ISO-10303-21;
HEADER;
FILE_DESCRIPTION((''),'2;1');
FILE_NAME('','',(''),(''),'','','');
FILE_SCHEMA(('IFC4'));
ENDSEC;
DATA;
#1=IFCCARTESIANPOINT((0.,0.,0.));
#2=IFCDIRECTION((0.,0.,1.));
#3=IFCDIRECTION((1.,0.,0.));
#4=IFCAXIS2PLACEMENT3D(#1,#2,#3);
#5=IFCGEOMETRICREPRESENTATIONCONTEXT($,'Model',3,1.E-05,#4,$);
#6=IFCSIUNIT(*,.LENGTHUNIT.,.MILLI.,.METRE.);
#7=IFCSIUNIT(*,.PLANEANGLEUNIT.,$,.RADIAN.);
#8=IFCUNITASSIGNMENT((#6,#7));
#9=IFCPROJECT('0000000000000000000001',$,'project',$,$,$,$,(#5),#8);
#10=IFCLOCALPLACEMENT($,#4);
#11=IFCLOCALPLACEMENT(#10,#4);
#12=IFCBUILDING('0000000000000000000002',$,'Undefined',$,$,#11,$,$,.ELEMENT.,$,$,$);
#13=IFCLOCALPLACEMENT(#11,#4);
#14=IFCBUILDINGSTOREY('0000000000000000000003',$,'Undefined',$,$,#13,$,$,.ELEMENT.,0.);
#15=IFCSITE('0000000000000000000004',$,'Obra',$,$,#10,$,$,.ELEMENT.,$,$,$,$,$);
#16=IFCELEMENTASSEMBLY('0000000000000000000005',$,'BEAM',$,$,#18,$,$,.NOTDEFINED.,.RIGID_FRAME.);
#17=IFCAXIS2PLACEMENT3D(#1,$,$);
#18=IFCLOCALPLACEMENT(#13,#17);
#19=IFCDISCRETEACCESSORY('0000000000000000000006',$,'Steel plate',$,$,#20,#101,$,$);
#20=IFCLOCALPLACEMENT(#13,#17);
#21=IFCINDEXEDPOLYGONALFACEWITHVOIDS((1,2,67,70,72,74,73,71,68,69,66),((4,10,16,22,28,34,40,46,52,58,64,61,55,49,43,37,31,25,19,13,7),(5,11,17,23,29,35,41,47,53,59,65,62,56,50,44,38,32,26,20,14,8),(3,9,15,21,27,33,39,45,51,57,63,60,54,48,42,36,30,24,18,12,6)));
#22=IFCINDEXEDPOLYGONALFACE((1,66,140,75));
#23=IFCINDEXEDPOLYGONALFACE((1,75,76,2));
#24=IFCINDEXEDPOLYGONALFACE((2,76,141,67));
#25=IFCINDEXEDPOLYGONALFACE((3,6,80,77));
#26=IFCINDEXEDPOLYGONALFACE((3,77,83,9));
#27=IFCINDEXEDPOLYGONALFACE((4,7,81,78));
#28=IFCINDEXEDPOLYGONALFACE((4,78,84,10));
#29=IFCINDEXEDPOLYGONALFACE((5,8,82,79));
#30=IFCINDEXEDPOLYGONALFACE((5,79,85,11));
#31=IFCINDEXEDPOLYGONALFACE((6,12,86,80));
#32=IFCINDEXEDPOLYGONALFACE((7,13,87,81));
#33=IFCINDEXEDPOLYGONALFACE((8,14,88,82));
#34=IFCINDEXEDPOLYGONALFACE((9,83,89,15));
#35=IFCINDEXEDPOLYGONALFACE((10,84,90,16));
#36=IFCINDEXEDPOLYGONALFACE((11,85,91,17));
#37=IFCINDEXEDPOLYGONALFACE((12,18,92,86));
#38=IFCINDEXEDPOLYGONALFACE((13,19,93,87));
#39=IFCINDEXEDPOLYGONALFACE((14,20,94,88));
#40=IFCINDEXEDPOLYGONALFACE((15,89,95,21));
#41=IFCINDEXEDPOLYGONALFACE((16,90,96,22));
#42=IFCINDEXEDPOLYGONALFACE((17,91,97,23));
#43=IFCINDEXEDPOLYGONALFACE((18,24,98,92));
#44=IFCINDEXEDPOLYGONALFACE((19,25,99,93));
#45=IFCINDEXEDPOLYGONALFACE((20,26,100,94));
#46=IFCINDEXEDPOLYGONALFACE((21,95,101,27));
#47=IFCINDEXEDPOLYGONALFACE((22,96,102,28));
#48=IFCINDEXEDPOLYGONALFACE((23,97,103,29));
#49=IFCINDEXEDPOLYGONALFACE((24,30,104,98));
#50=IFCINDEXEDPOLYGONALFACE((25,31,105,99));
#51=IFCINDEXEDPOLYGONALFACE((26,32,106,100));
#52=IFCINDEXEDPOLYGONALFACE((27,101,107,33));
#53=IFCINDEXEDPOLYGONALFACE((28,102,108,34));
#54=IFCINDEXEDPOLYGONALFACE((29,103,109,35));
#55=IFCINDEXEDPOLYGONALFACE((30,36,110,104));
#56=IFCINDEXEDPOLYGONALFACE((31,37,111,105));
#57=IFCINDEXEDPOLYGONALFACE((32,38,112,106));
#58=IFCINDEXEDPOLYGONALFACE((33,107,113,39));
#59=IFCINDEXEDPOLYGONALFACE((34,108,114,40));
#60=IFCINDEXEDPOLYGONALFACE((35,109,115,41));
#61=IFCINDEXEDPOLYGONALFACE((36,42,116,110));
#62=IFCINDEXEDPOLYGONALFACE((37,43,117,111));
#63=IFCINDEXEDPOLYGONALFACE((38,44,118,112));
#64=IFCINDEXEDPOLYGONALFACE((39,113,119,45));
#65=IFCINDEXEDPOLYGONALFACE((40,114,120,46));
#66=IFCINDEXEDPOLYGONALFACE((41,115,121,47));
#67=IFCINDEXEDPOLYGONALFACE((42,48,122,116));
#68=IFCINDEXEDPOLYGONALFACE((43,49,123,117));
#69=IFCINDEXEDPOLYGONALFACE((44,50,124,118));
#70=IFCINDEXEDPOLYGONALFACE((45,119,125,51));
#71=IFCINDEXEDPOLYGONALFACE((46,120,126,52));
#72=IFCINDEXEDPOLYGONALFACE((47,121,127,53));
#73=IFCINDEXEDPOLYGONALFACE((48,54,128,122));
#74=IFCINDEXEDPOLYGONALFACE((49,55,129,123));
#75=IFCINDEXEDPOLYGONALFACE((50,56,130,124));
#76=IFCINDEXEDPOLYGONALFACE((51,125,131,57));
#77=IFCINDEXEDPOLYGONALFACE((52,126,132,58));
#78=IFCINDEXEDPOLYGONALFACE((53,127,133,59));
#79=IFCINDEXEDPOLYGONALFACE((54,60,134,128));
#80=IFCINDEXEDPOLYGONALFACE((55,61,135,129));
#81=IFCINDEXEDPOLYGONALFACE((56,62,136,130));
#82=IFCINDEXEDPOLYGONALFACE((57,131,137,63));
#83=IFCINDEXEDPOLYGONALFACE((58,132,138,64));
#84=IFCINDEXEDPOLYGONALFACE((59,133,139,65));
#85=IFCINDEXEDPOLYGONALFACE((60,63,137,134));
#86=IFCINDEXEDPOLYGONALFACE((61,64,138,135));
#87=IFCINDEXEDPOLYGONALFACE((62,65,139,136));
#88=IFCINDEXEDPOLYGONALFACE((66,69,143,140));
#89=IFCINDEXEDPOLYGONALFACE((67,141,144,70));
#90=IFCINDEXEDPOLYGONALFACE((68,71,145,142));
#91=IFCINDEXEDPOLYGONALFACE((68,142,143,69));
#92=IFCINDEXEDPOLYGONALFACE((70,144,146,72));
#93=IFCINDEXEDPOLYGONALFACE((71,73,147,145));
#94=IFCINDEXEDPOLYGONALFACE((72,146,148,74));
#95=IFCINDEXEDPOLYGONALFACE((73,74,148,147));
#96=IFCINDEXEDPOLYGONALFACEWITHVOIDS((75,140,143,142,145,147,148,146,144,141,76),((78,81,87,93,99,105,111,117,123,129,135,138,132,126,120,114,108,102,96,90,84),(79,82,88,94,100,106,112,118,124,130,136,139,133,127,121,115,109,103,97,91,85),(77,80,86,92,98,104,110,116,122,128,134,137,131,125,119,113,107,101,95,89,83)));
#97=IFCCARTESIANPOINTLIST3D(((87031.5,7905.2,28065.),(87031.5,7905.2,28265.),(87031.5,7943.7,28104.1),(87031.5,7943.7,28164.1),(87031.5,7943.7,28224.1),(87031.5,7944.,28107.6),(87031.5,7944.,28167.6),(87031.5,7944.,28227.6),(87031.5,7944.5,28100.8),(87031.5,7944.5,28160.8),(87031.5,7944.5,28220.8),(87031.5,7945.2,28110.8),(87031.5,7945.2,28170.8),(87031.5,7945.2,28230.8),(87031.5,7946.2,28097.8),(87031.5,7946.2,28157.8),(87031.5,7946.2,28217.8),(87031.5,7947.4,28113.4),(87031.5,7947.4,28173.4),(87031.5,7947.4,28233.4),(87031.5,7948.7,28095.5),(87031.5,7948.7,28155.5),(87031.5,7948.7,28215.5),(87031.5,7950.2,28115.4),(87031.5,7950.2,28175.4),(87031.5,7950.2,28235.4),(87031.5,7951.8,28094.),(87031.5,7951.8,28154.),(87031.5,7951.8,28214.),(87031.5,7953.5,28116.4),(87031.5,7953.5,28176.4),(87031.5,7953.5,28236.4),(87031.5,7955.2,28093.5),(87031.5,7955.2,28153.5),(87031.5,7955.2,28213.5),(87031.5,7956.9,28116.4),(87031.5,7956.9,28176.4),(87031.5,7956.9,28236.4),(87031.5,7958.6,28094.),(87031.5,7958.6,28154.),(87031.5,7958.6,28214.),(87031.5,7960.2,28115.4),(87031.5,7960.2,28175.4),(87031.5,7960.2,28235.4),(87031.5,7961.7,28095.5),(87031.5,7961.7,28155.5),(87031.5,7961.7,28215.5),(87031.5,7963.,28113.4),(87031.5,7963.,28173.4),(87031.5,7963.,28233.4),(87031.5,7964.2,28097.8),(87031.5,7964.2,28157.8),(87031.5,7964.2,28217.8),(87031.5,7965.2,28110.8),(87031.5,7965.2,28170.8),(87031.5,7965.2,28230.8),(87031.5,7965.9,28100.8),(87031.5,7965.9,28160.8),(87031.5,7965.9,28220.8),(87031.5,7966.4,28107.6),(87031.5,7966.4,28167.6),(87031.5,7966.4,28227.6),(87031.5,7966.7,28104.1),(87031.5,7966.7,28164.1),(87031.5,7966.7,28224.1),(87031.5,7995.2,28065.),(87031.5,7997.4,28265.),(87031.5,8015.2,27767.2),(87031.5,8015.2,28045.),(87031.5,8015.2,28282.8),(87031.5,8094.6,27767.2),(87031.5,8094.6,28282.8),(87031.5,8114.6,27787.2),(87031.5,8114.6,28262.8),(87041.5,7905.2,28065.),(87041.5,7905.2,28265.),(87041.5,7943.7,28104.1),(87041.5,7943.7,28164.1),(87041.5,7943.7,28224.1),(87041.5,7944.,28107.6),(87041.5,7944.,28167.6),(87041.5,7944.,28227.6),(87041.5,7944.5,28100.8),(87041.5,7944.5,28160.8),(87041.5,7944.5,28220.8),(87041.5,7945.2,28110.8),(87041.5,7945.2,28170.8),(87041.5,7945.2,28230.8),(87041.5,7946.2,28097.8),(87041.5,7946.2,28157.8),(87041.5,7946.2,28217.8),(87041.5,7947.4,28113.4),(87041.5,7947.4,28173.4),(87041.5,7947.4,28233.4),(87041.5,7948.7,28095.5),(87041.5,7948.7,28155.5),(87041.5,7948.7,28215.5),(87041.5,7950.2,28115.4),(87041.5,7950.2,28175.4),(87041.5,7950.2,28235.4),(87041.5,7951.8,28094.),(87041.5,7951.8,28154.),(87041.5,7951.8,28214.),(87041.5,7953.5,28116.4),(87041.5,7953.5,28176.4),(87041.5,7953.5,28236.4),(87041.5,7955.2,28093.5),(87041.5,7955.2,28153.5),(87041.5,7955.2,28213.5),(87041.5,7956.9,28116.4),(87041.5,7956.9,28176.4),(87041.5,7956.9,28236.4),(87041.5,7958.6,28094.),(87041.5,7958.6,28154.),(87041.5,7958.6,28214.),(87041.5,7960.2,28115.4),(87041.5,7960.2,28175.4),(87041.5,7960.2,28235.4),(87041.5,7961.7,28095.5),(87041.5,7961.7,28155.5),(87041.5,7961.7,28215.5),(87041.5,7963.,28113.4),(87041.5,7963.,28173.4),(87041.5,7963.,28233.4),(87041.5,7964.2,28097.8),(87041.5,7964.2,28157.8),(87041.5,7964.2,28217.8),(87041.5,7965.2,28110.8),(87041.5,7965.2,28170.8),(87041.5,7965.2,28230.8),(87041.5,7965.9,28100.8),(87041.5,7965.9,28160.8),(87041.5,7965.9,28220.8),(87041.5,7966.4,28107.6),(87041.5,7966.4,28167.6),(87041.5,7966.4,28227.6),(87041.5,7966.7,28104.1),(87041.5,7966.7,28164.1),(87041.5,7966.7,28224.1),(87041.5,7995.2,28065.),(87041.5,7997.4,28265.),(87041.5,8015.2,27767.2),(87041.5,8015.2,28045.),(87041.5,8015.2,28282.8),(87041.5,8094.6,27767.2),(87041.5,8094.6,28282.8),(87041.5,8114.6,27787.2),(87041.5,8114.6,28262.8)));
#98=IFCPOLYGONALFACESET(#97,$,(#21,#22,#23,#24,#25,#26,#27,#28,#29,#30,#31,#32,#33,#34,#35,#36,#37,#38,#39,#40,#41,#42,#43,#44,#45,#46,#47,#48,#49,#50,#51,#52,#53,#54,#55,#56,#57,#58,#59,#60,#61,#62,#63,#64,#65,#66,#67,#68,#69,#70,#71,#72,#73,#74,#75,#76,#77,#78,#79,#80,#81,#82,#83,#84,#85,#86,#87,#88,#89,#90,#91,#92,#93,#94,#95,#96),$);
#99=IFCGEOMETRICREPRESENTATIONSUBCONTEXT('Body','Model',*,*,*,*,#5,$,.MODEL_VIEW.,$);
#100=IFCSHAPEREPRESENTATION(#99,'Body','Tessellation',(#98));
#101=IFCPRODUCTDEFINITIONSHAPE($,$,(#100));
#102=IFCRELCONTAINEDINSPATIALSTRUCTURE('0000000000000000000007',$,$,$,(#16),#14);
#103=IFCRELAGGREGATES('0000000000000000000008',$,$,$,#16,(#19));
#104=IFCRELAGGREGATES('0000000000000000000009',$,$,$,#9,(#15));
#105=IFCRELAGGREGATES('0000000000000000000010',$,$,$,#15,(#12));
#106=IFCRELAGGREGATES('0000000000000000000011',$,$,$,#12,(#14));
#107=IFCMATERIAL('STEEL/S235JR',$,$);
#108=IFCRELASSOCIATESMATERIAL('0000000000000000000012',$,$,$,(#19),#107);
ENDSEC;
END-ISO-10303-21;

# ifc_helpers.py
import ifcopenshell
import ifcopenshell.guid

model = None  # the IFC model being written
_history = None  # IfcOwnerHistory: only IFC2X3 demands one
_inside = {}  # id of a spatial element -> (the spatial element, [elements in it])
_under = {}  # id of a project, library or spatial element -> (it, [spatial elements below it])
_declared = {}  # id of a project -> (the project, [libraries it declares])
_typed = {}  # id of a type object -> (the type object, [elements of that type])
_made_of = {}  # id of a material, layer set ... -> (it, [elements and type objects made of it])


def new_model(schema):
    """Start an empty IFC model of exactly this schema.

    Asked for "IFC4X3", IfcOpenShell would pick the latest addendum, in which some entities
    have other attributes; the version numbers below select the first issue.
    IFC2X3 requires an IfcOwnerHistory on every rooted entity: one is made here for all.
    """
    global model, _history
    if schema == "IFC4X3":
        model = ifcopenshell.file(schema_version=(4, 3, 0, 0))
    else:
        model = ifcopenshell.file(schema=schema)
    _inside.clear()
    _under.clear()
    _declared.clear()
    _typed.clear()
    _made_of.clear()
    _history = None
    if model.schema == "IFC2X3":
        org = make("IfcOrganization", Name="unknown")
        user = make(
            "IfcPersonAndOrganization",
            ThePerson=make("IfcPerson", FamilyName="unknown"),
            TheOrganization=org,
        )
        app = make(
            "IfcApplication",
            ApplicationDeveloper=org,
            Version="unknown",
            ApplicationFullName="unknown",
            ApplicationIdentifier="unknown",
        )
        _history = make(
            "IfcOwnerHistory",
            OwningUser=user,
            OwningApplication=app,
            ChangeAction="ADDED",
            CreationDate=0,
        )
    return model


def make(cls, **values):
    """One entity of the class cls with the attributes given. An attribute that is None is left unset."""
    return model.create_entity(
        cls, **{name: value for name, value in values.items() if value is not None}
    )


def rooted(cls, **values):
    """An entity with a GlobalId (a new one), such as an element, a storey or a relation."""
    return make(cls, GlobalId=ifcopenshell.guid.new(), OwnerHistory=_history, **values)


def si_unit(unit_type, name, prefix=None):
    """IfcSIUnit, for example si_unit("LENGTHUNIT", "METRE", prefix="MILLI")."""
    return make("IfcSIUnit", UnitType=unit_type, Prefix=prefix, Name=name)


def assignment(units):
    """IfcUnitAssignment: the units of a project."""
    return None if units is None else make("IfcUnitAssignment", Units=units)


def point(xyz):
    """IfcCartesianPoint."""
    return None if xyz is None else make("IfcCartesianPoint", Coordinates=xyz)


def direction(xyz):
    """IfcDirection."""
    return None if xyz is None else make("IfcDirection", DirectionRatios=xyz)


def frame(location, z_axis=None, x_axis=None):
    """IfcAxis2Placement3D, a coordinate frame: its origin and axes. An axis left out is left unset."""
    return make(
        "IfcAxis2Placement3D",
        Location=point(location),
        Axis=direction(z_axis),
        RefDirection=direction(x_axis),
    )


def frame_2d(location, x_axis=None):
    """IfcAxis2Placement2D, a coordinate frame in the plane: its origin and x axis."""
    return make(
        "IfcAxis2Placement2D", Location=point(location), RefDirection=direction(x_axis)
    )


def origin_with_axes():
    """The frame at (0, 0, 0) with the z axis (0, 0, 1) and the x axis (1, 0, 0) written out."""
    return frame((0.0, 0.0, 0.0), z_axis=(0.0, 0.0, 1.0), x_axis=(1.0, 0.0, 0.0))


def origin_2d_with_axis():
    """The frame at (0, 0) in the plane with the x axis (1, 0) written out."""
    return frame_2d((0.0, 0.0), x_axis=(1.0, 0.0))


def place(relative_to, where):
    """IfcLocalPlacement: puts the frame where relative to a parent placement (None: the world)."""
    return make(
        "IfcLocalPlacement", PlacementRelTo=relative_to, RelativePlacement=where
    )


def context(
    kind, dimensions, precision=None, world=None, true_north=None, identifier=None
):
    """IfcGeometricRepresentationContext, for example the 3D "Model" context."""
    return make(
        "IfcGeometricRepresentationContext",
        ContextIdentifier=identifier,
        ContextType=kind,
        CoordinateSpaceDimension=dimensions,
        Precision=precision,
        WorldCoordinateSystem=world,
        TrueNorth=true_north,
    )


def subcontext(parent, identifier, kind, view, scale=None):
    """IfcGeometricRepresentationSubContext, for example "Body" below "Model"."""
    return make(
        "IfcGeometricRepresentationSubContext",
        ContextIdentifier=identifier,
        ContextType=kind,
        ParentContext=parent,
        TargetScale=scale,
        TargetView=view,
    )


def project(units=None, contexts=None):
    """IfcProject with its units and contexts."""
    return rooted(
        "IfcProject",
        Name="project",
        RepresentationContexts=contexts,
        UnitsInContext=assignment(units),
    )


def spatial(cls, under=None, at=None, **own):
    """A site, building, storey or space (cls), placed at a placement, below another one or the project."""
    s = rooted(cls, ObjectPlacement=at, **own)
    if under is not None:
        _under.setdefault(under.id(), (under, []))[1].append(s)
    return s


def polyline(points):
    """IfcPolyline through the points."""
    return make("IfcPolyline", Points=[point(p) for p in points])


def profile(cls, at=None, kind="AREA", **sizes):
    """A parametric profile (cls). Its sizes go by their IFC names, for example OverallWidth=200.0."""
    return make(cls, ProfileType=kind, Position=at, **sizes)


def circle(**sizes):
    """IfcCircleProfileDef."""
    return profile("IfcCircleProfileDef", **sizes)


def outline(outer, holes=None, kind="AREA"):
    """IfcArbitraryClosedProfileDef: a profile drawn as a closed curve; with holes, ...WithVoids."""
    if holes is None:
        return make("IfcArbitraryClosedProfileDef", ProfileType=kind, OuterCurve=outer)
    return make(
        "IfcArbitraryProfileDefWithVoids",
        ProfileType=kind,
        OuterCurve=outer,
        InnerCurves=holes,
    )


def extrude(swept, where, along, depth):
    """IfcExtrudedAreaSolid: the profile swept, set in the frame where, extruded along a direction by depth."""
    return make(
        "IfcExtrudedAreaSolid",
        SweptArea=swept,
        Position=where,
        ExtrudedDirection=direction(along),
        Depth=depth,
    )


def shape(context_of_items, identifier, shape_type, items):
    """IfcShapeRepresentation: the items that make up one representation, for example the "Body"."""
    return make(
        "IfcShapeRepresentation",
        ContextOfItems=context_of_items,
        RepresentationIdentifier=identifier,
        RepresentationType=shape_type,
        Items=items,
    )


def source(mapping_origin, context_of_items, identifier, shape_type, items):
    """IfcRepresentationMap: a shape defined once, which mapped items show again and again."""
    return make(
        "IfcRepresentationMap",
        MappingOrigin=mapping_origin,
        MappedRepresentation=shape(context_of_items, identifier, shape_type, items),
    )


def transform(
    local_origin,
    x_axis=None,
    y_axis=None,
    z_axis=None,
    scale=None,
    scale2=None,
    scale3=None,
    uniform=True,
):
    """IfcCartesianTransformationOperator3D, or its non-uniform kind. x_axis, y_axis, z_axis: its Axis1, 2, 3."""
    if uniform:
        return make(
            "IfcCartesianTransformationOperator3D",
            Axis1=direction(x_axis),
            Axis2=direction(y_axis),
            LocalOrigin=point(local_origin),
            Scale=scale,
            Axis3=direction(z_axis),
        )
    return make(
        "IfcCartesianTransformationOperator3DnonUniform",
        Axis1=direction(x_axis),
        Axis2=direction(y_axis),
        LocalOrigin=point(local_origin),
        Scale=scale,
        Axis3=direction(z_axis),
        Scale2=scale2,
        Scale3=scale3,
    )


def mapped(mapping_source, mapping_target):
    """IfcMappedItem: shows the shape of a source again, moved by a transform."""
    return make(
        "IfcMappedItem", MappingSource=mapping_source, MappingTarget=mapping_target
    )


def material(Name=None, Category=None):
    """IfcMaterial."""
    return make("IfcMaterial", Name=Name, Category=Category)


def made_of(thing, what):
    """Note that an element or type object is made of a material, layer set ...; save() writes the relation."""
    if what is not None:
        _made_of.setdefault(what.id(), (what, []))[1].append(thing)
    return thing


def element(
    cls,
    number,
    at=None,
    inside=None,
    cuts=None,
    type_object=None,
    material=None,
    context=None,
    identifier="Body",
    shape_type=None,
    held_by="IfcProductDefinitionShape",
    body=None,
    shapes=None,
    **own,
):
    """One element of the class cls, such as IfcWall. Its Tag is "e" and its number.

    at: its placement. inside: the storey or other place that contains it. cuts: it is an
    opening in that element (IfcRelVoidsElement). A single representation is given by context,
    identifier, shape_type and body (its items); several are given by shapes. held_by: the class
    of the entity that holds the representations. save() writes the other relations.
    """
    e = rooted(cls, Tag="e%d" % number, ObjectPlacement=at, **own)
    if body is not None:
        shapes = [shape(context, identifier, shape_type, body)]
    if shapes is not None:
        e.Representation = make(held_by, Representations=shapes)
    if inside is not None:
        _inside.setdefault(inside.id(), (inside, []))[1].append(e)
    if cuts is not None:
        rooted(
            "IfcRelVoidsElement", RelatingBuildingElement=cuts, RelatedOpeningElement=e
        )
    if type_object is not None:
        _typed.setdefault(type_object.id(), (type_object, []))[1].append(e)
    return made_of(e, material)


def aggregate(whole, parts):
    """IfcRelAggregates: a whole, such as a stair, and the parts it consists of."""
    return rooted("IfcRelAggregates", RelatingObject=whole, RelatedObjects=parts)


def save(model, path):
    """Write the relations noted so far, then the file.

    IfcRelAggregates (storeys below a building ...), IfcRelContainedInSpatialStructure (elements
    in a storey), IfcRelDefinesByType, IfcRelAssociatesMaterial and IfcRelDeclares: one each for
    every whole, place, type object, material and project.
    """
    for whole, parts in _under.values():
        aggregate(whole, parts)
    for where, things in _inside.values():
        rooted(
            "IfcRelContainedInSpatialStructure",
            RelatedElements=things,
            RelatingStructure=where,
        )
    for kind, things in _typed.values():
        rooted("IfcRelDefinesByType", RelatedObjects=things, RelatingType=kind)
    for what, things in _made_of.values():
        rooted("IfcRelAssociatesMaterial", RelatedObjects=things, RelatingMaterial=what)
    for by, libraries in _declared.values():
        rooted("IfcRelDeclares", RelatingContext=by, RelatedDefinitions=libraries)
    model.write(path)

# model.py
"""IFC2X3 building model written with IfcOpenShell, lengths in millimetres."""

from ifc_helpers import new_model, si_unit, frame, origin_with_axes, origin_2d_with_axis, place, context, subcontext, project, spatial, polyline, circle, outline, extrude, source, transform, mapped, material, element, aggregate, save


model = new_model("IFC2X3")

# Units and contexts
model_context = context("Model", 3, precision=1e-05, world=origin_with_axes())
body_context = subcontext(model_context, "Body", "Model", "MODEL_VIEW")
ifc_project = project(units=[si_unit("LENGTHUNIT", "METRE", prefix="MILLI"), si_unit("PLANEANGLEUNIT", "RADIAN")], contexts=[model_context])

# Site, building, storey
site_placement = place(None, origin_with_axes())
site = spatial("IfcSite", under=ifc_project, at=site_placement, Name="Obra", CompositionType="ELEMENT")
building_placement = place(site_placement, origin_with_axes())
building = spatial("IfcBuilding", under=site, at=building_placement, Name="Undefined", CompositionType="ELEMENT")
storey_placement = place(building_placement, origin_with_axes())
storey = spatial("IfcBuildingStorey", under=building, at=storey_placement, Name="Undefined", CompositionType="ELEMENT", Elevation=0.0)

# Shared definitions
ifc_material = material(Name="STEEL/S235JR")

# Element assembly, discrete accessory, opening
assembly_1_placement = place(storey_placement, origin_with_axes())
assembly_1 = element("IfcElementAssembly", 1, at=assembly_1_placement, inside=storey, Name="BEAM", AssemblyPlace="NOTDEFINED", PredefinedType="RIGID_FRAME")
discrete_accessory_1_placement = place(assembly_1_placement, frame((87036.5, 8114.6, 27787.2), z_axis=(-1.0, 0.000002, 0.0), x_axis=(0.0, -0.707107, -0.707107)))
discrete_accessory_1 = element("IfcDiscreteAccessory", 2, at=discrete_accessory_1_placement, material=ifc_material, Name="Steel plate", context=body_context, shape_type="SweptSolid", body=[
    extrude(outline(polyline([(0.0, 0.0), (28.3, 0.0), (84.5, 56.2), (-112.0, 252.6), (-112.0, 280.9), (-48.3, 344.5), (-189.8, 486.0), (-254.9, 420.8), (-280.1, 420.8), (-280.1, 420.8), (-336.3, 364.6), (-336.3, 336.3), (0.0, 0.0)])), frame((0.0, 0.0, -5.0), z_axis=(0.0, 0.0, 1.0), x_axis=(1.0, 0.0, 0.0)), (0.0, 0.0, 1.0), 10.0),
])
shared_shape_1 = source(origin_with_axes(), body_context, "Body", "SweptSolid", [
    extrude(circle(Radius=11.5, at=origin_2d_with_axis()), frame((0.0, -13.4, 0.0), z_axis=(0.0, 1.0, 0.0), x_axis=(1.0, 0.0, 0.0)), (0.0, 0.0, 1.0), 10.2),
])
opening_1_placement = place(assembly_1_placement, frame((87044.8, 8005.2, 28265.0), z_axis=(-0.000002, -1.0, 0.0), x_axis=(0.0, 0.0, -1.0)))
element("IfcOpeningElement", 3, at=opening_1_placement, cuts=discrete_accessory_1, ObjectType="Opening", context=body_context, shape_type="MappedRepresentation", body=[
    mapped(shared_shape_1, transform((40.0, 0.0, 50.0))),
    mapped(shared_shape_1, transform((100.0, 0.0, 50.0))),
    mapped(shared_shape_1, transform((160.0, 0.0, 50.0))),
])
aggregate(assembly_1, [discrete_accessory_1])

save(model, "model.ifc")
